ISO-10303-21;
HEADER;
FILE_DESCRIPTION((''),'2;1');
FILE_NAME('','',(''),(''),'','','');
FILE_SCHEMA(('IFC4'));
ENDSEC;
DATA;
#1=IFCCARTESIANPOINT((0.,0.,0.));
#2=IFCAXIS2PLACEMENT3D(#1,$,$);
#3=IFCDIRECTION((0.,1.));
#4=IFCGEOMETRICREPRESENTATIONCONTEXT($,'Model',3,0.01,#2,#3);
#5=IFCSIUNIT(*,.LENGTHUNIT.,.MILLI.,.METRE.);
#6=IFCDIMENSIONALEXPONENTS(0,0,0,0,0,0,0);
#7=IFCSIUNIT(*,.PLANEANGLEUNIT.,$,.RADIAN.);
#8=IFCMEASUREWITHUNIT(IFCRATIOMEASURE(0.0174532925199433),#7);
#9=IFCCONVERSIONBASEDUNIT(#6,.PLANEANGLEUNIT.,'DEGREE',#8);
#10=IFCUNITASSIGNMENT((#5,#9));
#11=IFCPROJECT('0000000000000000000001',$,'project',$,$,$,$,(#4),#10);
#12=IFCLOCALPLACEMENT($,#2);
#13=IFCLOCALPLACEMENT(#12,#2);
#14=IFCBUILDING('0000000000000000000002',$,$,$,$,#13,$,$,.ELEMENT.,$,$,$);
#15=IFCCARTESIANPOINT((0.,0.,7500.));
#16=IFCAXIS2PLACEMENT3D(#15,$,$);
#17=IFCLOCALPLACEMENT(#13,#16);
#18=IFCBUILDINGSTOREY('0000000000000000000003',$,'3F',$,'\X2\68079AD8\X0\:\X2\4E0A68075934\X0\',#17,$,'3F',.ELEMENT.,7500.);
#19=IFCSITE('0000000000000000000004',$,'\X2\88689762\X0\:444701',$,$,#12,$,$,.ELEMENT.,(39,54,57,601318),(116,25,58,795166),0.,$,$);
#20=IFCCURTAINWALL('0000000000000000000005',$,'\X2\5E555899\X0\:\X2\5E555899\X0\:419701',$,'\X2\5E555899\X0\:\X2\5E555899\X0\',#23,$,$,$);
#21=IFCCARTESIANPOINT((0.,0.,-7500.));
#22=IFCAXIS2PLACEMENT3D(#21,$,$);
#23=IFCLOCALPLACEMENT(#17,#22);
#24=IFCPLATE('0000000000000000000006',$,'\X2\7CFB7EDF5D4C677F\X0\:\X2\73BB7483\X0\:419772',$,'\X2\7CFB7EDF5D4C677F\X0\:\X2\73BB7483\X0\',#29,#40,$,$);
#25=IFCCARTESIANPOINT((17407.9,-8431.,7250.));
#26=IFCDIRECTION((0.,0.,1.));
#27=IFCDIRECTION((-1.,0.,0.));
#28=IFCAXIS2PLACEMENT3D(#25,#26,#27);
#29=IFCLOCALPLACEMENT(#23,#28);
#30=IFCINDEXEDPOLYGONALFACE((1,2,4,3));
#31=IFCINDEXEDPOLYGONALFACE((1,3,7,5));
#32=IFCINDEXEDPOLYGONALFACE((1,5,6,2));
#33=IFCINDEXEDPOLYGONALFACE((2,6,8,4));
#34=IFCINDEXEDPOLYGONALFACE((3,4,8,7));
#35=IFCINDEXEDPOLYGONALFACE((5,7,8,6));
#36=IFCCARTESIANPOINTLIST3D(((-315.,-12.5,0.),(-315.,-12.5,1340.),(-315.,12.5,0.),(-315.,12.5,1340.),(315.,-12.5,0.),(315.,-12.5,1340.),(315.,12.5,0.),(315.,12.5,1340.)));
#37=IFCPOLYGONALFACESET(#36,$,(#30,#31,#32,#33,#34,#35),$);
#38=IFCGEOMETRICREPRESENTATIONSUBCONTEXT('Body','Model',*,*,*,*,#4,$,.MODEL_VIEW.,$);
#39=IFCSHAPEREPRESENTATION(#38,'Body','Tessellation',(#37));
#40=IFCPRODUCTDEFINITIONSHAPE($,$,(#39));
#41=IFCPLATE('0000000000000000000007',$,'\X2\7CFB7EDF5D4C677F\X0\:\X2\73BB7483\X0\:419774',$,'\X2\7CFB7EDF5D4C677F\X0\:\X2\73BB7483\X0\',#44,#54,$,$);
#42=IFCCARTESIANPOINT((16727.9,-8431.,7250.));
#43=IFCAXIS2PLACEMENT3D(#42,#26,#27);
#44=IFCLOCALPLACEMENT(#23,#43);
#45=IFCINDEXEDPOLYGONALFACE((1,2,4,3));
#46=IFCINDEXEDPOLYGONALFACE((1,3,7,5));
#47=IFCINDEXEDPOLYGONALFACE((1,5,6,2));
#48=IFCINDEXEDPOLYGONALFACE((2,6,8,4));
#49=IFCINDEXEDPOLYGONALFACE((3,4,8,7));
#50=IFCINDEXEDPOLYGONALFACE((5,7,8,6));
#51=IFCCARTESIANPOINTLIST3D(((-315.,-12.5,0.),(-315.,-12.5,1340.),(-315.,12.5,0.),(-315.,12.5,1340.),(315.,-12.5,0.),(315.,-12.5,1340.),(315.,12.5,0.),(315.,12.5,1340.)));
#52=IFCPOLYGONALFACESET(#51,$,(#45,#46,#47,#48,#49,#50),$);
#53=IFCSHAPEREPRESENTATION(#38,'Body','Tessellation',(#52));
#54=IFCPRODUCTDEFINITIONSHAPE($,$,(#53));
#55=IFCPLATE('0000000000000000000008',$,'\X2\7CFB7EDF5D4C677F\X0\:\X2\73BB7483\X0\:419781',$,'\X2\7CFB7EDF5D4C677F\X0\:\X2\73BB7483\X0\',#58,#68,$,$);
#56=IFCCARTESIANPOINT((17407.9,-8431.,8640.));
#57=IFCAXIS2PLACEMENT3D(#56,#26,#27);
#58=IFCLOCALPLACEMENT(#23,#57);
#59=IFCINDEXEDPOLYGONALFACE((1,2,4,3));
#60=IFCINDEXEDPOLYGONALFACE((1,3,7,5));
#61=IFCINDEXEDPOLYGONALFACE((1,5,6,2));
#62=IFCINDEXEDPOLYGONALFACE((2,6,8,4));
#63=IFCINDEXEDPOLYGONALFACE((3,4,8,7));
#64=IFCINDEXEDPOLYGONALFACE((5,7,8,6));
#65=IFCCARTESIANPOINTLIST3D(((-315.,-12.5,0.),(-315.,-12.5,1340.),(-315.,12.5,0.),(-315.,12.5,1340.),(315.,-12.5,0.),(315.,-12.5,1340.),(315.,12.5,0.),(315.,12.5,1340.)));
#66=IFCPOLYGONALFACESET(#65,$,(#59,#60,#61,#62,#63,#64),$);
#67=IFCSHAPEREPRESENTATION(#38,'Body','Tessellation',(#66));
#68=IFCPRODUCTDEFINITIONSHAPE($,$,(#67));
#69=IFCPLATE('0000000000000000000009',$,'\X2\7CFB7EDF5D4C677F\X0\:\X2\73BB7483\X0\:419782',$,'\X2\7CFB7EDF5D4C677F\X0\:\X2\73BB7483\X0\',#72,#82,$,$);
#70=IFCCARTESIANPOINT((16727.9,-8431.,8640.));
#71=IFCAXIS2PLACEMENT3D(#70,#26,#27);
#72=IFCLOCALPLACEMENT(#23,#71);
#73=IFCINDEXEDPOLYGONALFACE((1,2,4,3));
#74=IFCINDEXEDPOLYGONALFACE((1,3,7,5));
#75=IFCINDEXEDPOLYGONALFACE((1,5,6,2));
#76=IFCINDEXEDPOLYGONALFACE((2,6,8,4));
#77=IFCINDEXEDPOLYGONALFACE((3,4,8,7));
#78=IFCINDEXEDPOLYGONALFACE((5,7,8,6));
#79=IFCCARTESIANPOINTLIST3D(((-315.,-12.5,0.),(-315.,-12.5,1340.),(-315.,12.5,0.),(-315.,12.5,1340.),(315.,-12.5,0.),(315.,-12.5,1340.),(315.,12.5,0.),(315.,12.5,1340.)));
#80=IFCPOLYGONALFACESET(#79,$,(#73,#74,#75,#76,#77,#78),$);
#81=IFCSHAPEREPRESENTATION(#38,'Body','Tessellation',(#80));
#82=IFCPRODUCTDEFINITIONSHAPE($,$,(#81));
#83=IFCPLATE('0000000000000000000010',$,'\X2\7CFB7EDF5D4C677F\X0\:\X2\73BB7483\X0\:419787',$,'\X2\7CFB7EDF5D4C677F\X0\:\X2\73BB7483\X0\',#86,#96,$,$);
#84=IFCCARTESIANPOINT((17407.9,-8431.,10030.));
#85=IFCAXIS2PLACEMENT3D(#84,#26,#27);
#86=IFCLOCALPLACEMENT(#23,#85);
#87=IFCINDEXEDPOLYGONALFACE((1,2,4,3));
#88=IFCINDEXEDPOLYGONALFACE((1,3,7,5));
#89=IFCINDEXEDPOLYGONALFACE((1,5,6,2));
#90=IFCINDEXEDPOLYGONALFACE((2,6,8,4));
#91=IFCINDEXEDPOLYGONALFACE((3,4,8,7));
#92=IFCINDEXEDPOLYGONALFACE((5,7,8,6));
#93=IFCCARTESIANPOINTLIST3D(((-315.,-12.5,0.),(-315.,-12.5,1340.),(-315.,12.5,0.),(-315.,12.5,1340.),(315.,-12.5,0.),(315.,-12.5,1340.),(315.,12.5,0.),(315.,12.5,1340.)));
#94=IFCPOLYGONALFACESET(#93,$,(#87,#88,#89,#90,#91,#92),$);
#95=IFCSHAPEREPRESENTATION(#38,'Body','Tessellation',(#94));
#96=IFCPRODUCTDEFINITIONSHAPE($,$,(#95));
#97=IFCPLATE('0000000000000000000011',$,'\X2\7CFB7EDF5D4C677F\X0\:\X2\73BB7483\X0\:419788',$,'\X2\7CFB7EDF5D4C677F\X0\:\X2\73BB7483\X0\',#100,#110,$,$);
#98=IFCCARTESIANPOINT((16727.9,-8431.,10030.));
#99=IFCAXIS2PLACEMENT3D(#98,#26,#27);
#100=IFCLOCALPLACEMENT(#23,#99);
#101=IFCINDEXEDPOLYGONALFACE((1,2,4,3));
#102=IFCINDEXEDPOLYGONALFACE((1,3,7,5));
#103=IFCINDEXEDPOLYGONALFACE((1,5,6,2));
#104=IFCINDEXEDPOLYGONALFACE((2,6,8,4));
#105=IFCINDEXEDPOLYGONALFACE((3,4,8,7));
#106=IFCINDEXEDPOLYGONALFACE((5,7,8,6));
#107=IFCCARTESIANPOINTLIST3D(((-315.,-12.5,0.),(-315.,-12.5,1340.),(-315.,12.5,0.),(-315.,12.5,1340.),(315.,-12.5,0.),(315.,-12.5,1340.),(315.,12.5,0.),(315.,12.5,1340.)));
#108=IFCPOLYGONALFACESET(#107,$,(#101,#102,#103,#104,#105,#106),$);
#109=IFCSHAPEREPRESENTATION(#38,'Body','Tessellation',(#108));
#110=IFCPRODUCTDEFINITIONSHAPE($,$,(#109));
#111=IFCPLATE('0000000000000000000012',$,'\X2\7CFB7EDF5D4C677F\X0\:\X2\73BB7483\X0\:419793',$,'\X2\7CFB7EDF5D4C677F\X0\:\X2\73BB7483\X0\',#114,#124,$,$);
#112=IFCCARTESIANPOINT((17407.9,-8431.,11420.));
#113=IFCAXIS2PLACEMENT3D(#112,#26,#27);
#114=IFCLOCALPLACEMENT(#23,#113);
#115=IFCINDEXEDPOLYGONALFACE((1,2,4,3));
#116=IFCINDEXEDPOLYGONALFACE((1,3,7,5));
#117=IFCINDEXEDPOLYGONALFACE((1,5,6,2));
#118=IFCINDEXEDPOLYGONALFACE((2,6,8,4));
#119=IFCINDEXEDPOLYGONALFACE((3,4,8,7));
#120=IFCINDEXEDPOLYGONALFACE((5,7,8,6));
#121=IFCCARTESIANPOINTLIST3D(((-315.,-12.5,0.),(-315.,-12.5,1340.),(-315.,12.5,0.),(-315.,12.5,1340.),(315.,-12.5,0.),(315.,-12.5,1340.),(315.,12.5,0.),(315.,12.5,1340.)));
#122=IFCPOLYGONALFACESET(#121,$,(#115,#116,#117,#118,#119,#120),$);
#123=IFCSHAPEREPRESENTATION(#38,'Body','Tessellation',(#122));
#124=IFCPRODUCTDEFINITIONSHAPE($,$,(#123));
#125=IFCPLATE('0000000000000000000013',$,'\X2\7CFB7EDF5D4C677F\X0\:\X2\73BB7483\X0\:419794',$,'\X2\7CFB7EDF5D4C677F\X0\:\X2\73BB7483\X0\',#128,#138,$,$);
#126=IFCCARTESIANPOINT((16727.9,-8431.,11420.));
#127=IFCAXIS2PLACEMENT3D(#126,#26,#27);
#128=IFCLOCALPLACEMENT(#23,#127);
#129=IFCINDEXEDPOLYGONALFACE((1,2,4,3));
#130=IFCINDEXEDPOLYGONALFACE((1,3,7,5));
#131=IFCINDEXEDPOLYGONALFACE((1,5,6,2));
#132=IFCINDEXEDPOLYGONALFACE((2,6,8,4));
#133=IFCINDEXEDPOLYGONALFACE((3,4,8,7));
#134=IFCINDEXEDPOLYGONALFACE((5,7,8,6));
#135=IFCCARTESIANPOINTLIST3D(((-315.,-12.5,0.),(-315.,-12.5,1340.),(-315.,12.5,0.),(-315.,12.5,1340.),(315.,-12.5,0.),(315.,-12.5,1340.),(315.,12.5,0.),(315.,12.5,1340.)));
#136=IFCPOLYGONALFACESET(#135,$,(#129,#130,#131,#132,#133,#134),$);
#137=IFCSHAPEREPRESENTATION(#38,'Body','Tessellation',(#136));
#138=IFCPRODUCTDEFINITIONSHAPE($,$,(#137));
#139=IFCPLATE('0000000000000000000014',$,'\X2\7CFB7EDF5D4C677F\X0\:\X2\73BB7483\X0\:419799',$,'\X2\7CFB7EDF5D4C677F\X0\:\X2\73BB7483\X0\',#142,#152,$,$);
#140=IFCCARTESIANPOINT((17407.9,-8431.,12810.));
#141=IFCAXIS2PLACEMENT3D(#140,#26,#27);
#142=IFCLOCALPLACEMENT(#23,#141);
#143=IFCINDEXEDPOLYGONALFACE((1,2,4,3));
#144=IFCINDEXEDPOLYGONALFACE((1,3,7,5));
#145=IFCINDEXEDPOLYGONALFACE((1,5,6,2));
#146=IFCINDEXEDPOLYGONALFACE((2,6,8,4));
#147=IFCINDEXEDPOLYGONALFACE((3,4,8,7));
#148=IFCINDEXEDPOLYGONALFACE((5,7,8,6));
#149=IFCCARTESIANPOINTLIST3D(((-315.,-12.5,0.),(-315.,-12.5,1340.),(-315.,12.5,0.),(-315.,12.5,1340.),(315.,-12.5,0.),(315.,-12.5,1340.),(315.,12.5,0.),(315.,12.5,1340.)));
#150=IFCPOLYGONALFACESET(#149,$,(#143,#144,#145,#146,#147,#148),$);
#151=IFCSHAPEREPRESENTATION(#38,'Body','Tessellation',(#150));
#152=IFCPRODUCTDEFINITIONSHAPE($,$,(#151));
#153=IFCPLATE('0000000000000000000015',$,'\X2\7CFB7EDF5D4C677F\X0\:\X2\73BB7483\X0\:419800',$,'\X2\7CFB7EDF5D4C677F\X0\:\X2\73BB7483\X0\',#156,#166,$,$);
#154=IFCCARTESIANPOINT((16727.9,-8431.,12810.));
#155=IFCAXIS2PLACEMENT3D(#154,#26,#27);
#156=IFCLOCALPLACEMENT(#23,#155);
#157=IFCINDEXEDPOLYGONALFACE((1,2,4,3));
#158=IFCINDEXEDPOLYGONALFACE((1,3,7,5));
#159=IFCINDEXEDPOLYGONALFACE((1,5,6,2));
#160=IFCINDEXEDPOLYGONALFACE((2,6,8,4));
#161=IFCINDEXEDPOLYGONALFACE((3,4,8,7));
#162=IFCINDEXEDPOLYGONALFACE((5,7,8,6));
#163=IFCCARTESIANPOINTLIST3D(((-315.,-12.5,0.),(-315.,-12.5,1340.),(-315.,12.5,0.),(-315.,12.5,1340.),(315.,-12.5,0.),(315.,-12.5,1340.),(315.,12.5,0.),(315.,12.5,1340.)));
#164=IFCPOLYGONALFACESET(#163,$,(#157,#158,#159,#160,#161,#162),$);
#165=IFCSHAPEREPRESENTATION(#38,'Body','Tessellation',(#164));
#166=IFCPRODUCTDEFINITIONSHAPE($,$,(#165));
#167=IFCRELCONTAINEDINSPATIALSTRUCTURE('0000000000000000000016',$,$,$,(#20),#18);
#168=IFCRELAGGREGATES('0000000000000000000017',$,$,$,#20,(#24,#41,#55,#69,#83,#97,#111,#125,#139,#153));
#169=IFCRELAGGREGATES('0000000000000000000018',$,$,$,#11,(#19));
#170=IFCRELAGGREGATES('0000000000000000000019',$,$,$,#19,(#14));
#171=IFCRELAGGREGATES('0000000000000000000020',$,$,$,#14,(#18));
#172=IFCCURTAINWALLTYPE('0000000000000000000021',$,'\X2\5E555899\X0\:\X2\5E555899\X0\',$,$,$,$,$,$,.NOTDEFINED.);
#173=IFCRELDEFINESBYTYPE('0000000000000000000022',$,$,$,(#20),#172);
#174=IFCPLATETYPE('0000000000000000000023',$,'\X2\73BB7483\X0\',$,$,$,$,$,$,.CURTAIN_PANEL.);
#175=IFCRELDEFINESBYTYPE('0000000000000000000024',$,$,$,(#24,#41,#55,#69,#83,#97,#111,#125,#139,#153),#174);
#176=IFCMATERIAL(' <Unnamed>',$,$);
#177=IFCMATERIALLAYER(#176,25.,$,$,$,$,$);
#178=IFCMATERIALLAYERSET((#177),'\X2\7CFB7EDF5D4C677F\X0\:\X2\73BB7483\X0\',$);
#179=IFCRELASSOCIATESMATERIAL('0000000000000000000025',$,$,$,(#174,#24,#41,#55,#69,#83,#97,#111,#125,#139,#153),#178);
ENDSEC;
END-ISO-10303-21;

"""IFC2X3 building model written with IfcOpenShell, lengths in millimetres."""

from ifc_helpers import new_model, entity, si_unit, converted_unit, direction, frame, origin, origin_2d_with_axis, place, context, subcontext, project, spatial, rectangle, extrude, source, transform, mapped, material, layer, layer_set, layer_usage, type_object, type_shapes, element, aggregate, save


model = new_model("IFC2X3")

# Units and contexts
model_context = context("Model", 3, precision=0.01, world=origin(), true_north=direction((0.0, 1.0)))
body_context = subcontext(model_context, "Body", "Model", "MODEL_VIEW")
ifc_project = project(units=[si_unit("LENGTHUNIT", "METRE", prefix="MILLI"), converted_unit("PLANEANGLEUNIT", "DEGREE", entity("IfcRatioMeasure", 0.0174532925199433), si_unit("PLANEANGLEUNIT", "RADIAN"), dimensions=[0, 0, 0, 0, 0, 0, 0])], contexts=[model_context])

# Site, building, storey
site_placement = place(None, origin())
site = spatial("IfcSite", under=ifc_project, at=site_placement, Name="表面:444701", CompositionType="ELEMENT", RefLatitude=(39, 54, 57, 601318), RefLongitude=(116, 25, 58, 795166), RefElevation=0.0)
building_placement = place(site_placement, origin())
building = spatial("IfcBuilding", under=site, at=building_placement, CompositionType="ELEMENT")
storey_placement = place(building_placement, frame((0.0, 0.0, 7500.0)))
storey = spatial("IfcBuildingStorey", under=building, at=storey_placement, Name="3F", ObjectType="标高:上标头", LongName="3F", CompositionType="ELEMENT", Elevation=7500.0)

# Curtain wall, plates
curtain_wall_type = type_object("IfcCurtainWallType", Name="幕墙:幕墙", PredefinedType="NOTDEFINED")
curtain_wall_placement = place(storey_placement, frame((0.0, 0.0, -7500.0)))
curtain_wall = element("IfcCurtainWall", 1, at=curtain_wall_placement, inside=storey, type_object=curtain_wall_type, Name="幕墙:幕墙:419701", ObjectType="幕墙:幕墙")
ifc_material_1 = material(Name=" <Unnamed>")
ifc_layer = layer(ifc_material_1, 25.0)
ifc_layer_set = layer_set([ifc_layer], Name="系统嵌板:玻璃")
ifc_layer_usage_1 = layer_usage(ifc_layer_set, "AXIS3", "POSITIVE", 0.0)
plate_type = type_object("IfcPlateType", Name="玻璃", PredefinedType="CURTAIN_PANEL", material=ifc_layer_set)
shared_shape_1 = source(origin(), body_context, "Body", "SweptSolid", [
    extrude(rectangle(XDim=25.0, YDim=630.0, at=origin_2d_with_axis()), frame((0.0, 0.0, 0.0), z_axis=(0.0, 0.0, 1.0), x_axis=(0.0, 1.0, 0.0)), (0.0, 0.0, 1.0), 1340.0),
])
type_shapes(plate_type, [shared_shape_1])
plate_1_placement = place(curtain_wall_placement, frame((17407.9, -8431.0, 7250.0), z_axis=(0.0, 0.0, 1.0), x_axis=(-1.0, 0.0, 0.0)))
plate_1 = element("IfcPlate", 2, at=plate_1_placement, type_object=plate_type, material=ifc_layer_usage_1, Name="系统嵌板:玻璃:419772", ObjectType="系统嵌板:玻璃", context=body_context, shape_type="MappedRepresentation", body=[
    mapped(shared_shape_1, transform((0.0, 0.0, 0.0), scale=1.0)),
])
ifc_layer_usage_2 = layer_usage(ifc_layer_set, "AXIS3", "POSITIVE", 0.0)
plate_2_placement = place(curtain_wall_placement, frame((16727.9, -8431.0, 7250.0), z_axis=(0.0, 0.0, 1.0), x_axis=(-1.0, 0.0, 0.0)))
plate_2 = element("IfcPlate", 3, at=plate_2_placement, type_object=plate_type, material=ifc_layer_usage_2, Name="系统嵌板:玻璃:419774", ObjectType="系统嵌板:玻璃", context=body_context, shape_type="MappedRepresentation", body=[
    mapped(shared_shape_1, transform((0.0, 0.0, 0.0), scale=1.0)),
])
ifc_layer_usage_3 = layer_usage(ifc_layer_set, "AXIS3", "POSITIVE", 0.0)
plate_3_placement = place(curtain_wall_placement, frame((17407.9, -8431.0, 8640.0), z_axis=(0.0, 0.0, 1.0), x_axis=(-1.0, 0.0, 0.0)))
plate_3 = element("IfcPlate", 4, at=plate_3_placement, type_object=plate_type, material=ifc_layer_usage_3, Name="系统嵌板:玻璃:419781", ObjectType="系统嵌板:玻璃", context=body_context, shape_type="MappedRepresentation", body=[
    mapped(shared_shape_1, transform((0.0, 0.0, 0.0), scale=1.0)),
])
ifc_layer_usage_4 = layer_usage(ifc_layer_set, "AXIS3", "POSITIVE", 0.0)
plate_4_placement = place(curtain_wall_placement, frame((16727.9, -8431.0, 8640.0), z_axis=(0.0, 0.0, 1.0), x_axis=(-1.0, 0.0, 0.0)))
plate_4 = element("IfcPlate", 5, at=plate_4_placement, type_object=plate_type, material=ifc_layer_usage_4, Name="系统嵌板:玻璃:419782", ObjectType="系统嵌板:玻璃", context=body_context, shape_type="MappedRepresentation", body=[
    mapped(shared_shape_1, transform((0.0, 0.0, 0.0), scale=1.0)),
])
ifc_layer_usage_5 = layer_usage(ifc_layer_set, "AXIS3", "POSITIVE", 0.0)
plate_5_placement = place(curtain_wall_placement, frame((17407.9, -8431.0, 10030.0), z_axis=(0.0, 0.0, 1.0), x_axis=(-1.0, 0.0, 0.0)))
plate_5 = element("IfcPlate", 6, at=plate_5_placement, type_object=plate_type, material=ifc_layer_usage_5, Name="系统嵌板:玻璃:419787", ObjectType="系统嵌板:玻璃", context=body_context, shape_type="MappedRepresentation", body=[
    mapped(shared_shape_1, transform((0.0, 0.0, 0.0), scale=1.0)),
])
ifc_layer_usage_6 = layer_usage(ifc_layer_set, "AXIS3", "POSITIVE", 0.0)
plate_6_placement = place(curtain_wall_placement, frame((16727.9, -8431.0, 10030.0), z_axis=(0.0, 0.0, 1.0), x_axis=(-1.0, 0.0, 0.0)))
plate_6 = element("IfcPlate", 7, at=plate_6_placement, type_object=plate_type, material=ifc_layer_usage_6, Name="系统嵌板:玻璃:419788", ObjectType="系统嵌板:玻璃", context=body_context, shape_type="MappedRepresentation", body=[
    mapped(shared_shape_1, transform((0.0, 0.0, 0.0), scale=1.0)),
])
ifc_layer_usage_7 = layer_usage(ifc_layer_set, "AXIS3", "POSITIVE", 0.0)
plate_7_placement = place(curtain_wall_placement, frame((17407.9, -8431.0, 11420.0), z_axis=(0.0, 0.0, 1.0), x_axis=(-1.0, 0.0, 0.0)))
plate_7 = element("IfcPlate", 8, at=plate_7_placement, type_object=plate_type, material=ifc_layer_usage_7, Name="系统嵌板:玻璃:419793", ObjectType="系统嵌板:玻璃", context=body_context, shape_type="MappedRepresentation", body=[
    mapped(shared_shape_1, transform((0.0, 0.0, 0.0), scale=1.0)),
])
ifc_layer_usage_8 = layer_usage(ifc_layer_set, "AXIS3", "POSITIVE", 0.0)
plate_8_placement = place(curtain_wall_placement, frame((16727.9, -8431.0, 11420.0), z_axis=(0.0, 0.0, 1.0), x_axis=(-1.0, 0.0, 0.0)))
plate_8 = element("IfcPlate", 9, at=plate_8_placement, type_object=plate_type, material=ifc_layer_usage_8, Name="系统嵌板:玻璃:419794", ObjectType="系统嵌板:玻璃", context=body_context, shape_type="MappedRepresentation", body=[
    mapped(shared_shape_1, transform((0.0, 0.0, 0.0), scale=1.0)),
])
ifc_layer_usage_9 = layer_usage(ifc_layer_set, "AXIS3", "POSITIVE", 0.0)
plate_9_placement = place(curtain_wall_placement, frame((17407.9, -8431.0, 12810.0), z_axis=(0.0, 0.0, 1.0), x_axis=(-1.0, 0.0, 0.0)))
plate_9 = element("IfcPlate", 10, at=plate_9_placement, type_object=plate_type, material=ifc_layer_usage_9, Name="系统嵌板:玻璃:419799", ObjectType="系统嵌板:玻璃", context=body_context, shape_type="MappedRepresentation", body=[
    mapped(shared_shape_1, transform((0.0, 0.0, 0.0), scale=1.0)),
])
ifc_layer_usage_10 = layer_usage(ifc_layer_set, "AXIS3", "POSITIVE", 0.0)
plate_10_placement = place(curtain_wall_placement, frame((16727.9, -8431.0, 12810.0), z_axis=(0.0, 0.0, 1.0), x_axis=(-1.0, 0.0, 0.0)))
plate_10 = element("IfcPlate", 11, at=plate_10_placement, type_object=plate_type, material=ifc_layer_usage_10, Name="系统嵌板:玻璃:419800", ObjectType="系统嵌板:玻璃", context=body_context, shape_type="MappedRepresentation", body=[
    mapped(shared_shape_1, transform((0.0, 0.0, 0.0), scale=1.0)),
])
aggregate(curtain_wall, [plate_1, plate_2, plate_3, plate_4, plate_5, plate_6, plate_7, plate_8, plate_9, plate_10])

save(model, "model.ifc")
